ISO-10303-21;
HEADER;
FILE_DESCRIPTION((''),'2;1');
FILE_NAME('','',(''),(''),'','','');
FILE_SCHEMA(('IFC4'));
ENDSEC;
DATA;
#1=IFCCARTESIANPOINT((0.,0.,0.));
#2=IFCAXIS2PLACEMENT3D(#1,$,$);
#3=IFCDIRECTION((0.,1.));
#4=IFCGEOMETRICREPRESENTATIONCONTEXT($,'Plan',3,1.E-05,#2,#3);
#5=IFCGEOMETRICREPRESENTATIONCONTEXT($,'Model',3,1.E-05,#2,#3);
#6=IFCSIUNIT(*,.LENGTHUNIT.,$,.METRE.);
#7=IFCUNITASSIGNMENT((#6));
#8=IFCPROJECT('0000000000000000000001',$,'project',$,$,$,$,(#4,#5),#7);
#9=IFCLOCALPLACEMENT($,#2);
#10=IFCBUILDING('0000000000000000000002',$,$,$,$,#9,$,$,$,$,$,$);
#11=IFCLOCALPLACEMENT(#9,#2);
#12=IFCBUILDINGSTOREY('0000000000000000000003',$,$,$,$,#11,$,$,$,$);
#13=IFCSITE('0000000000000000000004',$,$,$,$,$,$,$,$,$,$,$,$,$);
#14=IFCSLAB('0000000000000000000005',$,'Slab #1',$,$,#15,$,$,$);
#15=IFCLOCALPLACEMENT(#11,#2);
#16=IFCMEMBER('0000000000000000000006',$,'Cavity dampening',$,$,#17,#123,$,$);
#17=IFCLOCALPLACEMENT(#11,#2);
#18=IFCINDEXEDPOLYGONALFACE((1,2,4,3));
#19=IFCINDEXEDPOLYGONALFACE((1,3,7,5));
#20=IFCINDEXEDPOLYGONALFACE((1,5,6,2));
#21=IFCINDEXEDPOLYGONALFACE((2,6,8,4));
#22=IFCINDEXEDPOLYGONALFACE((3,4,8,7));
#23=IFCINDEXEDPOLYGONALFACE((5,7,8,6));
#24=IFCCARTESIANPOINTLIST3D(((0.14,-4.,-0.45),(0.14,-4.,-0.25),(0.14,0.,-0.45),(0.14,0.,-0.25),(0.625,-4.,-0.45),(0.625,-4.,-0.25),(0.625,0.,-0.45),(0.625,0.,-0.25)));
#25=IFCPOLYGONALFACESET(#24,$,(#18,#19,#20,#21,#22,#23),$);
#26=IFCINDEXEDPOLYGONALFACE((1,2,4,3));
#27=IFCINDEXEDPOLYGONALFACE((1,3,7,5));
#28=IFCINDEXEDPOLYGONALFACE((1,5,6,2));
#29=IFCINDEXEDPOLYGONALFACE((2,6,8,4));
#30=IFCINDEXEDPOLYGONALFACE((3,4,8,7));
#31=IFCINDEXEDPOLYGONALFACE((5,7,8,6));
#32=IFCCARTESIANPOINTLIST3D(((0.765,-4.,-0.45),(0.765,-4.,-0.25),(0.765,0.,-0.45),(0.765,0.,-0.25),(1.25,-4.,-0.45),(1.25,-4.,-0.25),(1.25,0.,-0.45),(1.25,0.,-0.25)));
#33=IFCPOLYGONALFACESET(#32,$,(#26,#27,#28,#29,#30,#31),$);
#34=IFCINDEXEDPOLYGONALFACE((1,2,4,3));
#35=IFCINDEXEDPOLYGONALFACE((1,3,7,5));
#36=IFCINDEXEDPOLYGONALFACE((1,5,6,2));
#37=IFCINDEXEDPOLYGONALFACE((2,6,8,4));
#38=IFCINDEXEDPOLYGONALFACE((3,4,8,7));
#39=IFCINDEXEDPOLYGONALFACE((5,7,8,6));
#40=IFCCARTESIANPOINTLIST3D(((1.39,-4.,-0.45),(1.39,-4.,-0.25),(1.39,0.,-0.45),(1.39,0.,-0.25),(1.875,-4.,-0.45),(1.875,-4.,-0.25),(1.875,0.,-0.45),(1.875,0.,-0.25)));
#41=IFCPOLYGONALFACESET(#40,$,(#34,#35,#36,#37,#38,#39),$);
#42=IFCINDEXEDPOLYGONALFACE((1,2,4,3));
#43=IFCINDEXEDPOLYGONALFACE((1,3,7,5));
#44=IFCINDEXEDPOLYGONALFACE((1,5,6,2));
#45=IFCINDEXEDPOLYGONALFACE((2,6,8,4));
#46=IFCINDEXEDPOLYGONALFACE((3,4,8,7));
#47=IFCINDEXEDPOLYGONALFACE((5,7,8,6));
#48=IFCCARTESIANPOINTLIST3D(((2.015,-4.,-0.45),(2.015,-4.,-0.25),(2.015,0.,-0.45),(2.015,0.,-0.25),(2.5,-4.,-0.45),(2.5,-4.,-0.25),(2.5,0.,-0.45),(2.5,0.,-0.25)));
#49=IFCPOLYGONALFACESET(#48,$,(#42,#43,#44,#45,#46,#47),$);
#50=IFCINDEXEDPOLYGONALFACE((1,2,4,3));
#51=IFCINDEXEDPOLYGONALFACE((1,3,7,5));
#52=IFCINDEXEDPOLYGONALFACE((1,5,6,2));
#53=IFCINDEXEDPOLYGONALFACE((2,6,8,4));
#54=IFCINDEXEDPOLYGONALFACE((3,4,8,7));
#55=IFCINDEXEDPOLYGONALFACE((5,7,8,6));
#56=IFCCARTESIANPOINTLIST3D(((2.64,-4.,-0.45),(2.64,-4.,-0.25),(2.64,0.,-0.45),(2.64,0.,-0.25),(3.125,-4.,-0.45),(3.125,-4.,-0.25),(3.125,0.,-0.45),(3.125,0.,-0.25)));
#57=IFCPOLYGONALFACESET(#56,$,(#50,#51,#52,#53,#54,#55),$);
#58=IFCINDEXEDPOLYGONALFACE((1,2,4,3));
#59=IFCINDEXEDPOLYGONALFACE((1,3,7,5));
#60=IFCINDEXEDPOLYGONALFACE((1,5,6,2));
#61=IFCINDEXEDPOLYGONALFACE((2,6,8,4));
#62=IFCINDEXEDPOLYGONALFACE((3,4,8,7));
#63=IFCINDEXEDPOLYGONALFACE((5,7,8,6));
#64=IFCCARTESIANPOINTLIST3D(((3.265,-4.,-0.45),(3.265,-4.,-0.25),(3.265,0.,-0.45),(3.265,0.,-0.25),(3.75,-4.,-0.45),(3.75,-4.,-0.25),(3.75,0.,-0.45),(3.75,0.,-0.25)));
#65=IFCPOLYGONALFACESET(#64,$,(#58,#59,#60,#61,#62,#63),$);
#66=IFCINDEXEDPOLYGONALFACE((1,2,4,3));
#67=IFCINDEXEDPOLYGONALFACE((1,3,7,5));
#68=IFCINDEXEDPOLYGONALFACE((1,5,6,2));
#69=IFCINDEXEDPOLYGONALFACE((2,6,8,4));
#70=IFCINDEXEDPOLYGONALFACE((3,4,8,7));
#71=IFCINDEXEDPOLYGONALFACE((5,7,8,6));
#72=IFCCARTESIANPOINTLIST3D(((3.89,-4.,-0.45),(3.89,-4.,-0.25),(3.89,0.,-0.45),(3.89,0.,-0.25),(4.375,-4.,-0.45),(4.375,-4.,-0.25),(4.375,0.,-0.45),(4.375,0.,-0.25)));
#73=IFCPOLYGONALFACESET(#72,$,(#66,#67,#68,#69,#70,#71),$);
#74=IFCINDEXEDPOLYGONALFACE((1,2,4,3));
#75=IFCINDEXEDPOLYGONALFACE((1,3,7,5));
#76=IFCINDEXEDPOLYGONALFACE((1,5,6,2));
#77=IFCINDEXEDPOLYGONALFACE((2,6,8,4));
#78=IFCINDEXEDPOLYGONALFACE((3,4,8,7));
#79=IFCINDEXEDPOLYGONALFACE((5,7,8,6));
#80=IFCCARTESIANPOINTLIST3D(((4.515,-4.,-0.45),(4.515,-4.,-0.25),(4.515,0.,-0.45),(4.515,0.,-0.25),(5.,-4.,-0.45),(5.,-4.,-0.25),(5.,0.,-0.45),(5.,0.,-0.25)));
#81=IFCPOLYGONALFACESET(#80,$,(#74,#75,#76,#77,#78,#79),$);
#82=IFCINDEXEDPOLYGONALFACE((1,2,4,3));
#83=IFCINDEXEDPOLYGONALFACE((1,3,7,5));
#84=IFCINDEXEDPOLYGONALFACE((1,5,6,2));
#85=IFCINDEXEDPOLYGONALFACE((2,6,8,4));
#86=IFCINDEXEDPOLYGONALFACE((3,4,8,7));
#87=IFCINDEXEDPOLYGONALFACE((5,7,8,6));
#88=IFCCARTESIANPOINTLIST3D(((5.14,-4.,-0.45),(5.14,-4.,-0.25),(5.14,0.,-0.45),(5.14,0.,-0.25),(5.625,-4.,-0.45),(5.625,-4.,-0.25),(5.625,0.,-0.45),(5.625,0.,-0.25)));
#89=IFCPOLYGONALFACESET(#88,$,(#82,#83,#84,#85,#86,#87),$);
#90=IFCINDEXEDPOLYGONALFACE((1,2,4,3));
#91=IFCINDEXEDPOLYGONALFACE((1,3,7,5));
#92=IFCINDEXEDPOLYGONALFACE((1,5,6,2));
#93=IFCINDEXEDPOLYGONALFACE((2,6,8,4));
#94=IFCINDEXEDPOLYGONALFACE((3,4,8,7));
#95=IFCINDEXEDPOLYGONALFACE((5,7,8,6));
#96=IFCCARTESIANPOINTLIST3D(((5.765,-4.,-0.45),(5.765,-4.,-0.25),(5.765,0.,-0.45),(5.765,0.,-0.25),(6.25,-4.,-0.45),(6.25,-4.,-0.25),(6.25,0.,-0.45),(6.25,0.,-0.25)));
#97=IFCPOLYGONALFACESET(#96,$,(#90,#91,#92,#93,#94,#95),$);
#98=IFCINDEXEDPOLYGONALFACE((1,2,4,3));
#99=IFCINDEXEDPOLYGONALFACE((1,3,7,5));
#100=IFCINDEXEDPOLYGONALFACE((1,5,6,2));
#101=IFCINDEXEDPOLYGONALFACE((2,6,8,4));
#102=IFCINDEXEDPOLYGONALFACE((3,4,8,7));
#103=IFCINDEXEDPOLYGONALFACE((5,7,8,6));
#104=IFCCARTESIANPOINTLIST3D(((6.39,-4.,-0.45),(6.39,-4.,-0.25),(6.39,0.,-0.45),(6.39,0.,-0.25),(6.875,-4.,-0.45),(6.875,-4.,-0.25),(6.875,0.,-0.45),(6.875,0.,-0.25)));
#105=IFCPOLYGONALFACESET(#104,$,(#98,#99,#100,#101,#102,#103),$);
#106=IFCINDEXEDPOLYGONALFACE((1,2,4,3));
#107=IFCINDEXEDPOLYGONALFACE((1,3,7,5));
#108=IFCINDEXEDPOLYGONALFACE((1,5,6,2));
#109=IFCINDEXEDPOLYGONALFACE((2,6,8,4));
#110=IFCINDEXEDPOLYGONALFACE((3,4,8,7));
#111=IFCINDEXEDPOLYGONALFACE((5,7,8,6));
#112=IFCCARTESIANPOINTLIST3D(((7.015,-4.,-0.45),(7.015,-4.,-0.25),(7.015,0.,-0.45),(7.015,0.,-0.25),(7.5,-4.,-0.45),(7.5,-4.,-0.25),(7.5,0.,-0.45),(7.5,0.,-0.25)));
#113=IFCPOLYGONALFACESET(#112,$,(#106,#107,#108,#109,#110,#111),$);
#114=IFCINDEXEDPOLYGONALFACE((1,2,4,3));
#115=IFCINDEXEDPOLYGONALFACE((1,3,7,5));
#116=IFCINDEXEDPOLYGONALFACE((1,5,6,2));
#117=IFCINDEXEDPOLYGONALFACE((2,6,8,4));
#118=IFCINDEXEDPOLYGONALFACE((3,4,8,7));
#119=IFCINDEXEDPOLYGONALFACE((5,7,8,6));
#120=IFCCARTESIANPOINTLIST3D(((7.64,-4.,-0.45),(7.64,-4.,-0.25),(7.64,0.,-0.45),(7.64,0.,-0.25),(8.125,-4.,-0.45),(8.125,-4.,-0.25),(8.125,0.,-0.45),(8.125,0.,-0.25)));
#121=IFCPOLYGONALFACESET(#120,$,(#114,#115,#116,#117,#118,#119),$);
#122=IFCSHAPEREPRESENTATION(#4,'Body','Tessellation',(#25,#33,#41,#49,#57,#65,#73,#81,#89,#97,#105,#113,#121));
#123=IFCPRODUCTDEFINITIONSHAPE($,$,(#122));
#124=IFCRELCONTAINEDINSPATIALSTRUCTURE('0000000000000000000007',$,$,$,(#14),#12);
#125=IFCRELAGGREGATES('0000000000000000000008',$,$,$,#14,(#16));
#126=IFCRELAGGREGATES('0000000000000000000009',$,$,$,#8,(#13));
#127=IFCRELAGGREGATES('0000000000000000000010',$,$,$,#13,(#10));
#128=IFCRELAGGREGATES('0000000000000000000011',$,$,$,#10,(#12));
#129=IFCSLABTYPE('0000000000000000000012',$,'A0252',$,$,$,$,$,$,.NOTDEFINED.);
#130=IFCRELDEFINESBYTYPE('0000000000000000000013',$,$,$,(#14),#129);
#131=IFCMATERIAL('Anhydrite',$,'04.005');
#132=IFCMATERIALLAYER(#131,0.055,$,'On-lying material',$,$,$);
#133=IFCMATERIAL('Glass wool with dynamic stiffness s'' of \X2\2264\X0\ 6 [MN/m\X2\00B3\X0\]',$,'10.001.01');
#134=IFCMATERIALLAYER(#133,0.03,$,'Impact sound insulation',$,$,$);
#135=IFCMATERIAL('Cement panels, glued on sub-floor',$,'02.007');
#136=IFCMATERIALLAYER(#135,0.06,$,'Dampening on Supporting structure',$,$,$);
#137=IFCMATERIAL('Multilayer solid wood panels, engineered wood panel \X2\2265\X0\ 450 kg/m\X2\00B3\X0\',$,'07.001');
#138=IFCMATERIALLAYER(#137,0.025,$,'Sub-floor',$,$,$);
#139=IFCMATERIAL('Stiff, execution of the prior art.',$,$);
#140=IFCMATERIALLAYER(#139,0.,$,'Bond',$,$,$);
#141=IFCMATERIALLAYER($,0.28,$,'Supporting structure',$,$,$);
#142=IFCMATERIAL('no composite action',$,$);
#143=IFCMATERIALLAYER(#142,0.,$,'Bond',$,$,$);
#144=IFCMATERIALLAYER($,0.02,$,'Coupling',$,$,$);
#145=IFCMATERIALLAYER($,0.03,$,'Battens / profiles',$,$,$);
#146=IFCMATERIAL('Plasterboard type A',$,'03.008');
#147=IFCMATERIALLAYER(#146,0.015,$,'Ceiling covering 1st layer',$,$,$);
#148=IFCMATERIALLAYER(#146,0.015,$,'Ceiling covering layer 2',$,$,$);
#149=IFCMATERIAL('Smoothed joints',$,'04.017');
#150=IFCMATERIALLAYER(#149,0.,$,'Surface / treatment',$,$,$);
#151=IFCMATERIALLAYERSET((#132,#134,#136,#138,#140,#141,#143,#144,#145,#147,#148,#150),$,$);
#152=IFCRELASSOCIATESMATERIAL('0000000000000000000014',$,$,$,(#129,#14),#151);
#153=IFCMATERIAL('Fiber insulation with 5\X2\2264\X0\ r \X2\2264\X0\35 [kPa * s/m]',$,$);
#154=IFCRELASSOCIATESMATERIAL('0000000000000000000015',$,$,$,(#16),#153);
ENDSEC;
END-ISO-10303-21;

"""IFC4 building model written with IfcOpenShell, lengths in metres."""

from ifc_helpers import new_model, si_unit, direction, frame, frame_2d, origin, place, context, project, spatial, rectangle, extrude, material, layer, layer_set, type_object, element, aggregate, save


model = new_model("IFC4")

# Units and contexts
plan_context = context("Plan", 3, precision=1e-05, world=origin(), true_north=direction((0.0, 1.0)))
model_context = context("Model", 3, precision=1e-05, world=origin(), true_north=direction((0.0, 1.0)))
ifc_project = project(units=[si_unit("LENGTHUNIT", "METRE")], contexts=[plan_context, model_context])

# Site, building, storey
site = spatial("IfcSite", under=ifc_project)
building_placement = place(None, origin())
building = spatial("IfcBuilding", under=site, at=building_placement)
storey_placement = place(building_placement, origin())
storey = spatial("IfcBuildingStorey", under=building, at=storey_placement)

# Slab, member
ifc_material_1 = material(Name="Anhydrite", Category="04.005")
ifc_layer_1 = layer(ifc_material_1, 0.055, Name="On-lying material")
ifc_material_2 = material(Name="Glass wool with dynamic stiffness s' of ≤ 6 [MN/m³]", Category="10.001.01")
ifc_layer_2 = layer(ifc_material_2, 0.03, Name="Impact sound insulation")
ifc_material_3 = material(Name="Cement panels, glued on sub-floor", Category="02.007")
ifc_layer_3 = layer(ifc_material_3, 0.06, Name="Dampening on Supporting structure")
ifc_material_4 = material(Name="Multilayer solid wood panels, engineered wood panel ≥ 450 kg/m³", Category="07.001")
ifc_layer_4 = layer(ifc_material_4, 0.025, Name="Sub-floor")
ifc_material_5 = material(Name="Stiff, execution of the prior art.")
ifc_layer_5 = layer(ifc_material_5, 0.0, Name="Bond")
ifc_layer_6 = layer(None, 0.28, Name="Supporting structure")
ifc_material_6 = material(Name="no composite action")
ifc_layer_7 = layer(ifc_material_6, 0.0, Name="Bond")
ifc_layer_8 = layer(None, 0.02, Name="Coupling")
ifc_layer_9 = layer(None, 0.03, Name="Battens / profiles")
ifc_material_7 = material(Name="Plasterboard type A", Category="03.008")
ifc_layer_10 = layer(ifc_material_7, 0.015, Name="Ceiling covering 1st layer")
ifc_layer_11 = layer(ifc_material_7, 0.015, Name="Ceiling covering layer 2")
ifc_material_8 = material(Name="Smoothed joints", Category="04.017")
ifc_layer_12 = layer(ifc_material_8, 0.0, Name="Surface / treatment")
ifc_layer_set = layer_set([ifc_layer_1, ifc_layer_2, ifc_layer_3, ifc_layer_4, ifc_layer_5, ifc_layer_6, ifc_layer_7, ifc_layer_8, ifc_layer_9, ifc_layer_10, ifc_layer_11, ifc_layer_12])
slab_type = type_object("IfcSlabType", Name="A0252", PredefinedType="NOTDEFINED", material=ifc_layer_set)
slab_placement = place(None, frame((0.0, 0.0, 0.0), z_axis=(0.0, 0.0, -1.0), x_axis=(1.0, 0.0, 0.0)))
slab = element("IfcSlab", 1, at=slab_placement, inside=storey, type_object=slab_type, material=ifc_layer_set, Name="Slab #1")
ifc_material_9 = material(Name="Fiber insulation with 5≤ r ≤35 [kPa * s/m]")
member_1_placement = place(slab_placement, origin())
member_1 = element("IfcMember", 2, at=member_1_placement, material=ifc_material_9, Name="Cavity dampening", context=plan_context, shape_type="SweptSolid", body=[
    extrude(rectangle(XDim=0.485, YDim=0.2, at=frame_2d((0.2425, 0.1), x_axis=(1.0, 0.0))), frame((0.14, 4.0, 0.25), z_axis=(0.0, -1.0, 0.0), x_axis=(1.0, 0.0, 0.0)), (0.0, 0.0, 1.0), 4.0),
    extrude(rectangle(XDim=0.485, YDim=0.2, at=frame_2d((0.2425, 0.1), x_axis=(1.0, 0.0))), frame((0.765, 4.0, 0.25), z_axis=(0.0, -1.0, 0.0), x_axis=(1.0, 0.0, 0.0)), (0.0, 0.0, 1.0), 4.0),
    extrude(rectangle(XDim=0.485, YDim=0.2, at=frame_2d((0.2425, 0.1), x_axis=(1.0, 0.0))), frame((1.39, 4.0, 0.25), z_axis=(0.0, -1.0, 0.0), x_axis=(1.0, 0.0, 0.0)), (0.0, 0.0, 1.0), 4.0),
    extrude(rectangle(XDim=0.485, YDim=0.2, at=frame_2d((0.2425, 0.1), x_axis=(1.0, 0.0))), frame((2.015, 4.0, 0.25), z_axis=(0.0, -1.0, 0.0), x_axis=(1.0, 0.0, 0.0)), (0.0, 0.0, 1.0), 4.0),
    extrude(rectangle(XDim=0.485, YDim=0.2, at=frame_2d((0.2425, 0.1), x_axis=(1.0, 0.0))), frame((2.64, 4.0, 0.25), z_axis=(0.0, -1.0, 0.0), x_axis=(1.0, 0.0, 0.0)), (0.0, 0.0, 1.0), 4.0),
    extrude(rectangle(XDim=0.485, YDim=0.2, at=frame_2d((0.2425, 0.1), x_axis=(1.0, 0.0))), frame((3.265, 4.0, 0.25), z_axis=(0.0, -1.0, 0.0), x_axis=(1.0, 0.0, 0.0)), (0.0, 0.0, 1.0), 4.0),
    extrude(rectangle(XDim=0.485, YDim=0.2, at=frame_2d((0.2425, 0.1), x_axis=(1.0, 0.0))), frame((3.89, 4.0, 0.25), z_axis=(0.0, -1.0, 0.0), x_axis=(1.0, 0.0, 0.0)), (0.0, 0.0, 1.0), 4.0),
    extrude(rectangle(XDim=0.485, YDim=0.2, at=frame_2d((0.2425, 0.1), x_axis=(1.0, 0.0))), frame((4.515, 4.0, 0.25), z_axis=(0.0, -1.0, 0.0), x_axis=(1.0, 0.0, 0.0)), (0.0, 0.0, 1.0), 4.0),
    extrude(rectangle(XDim=0.485, YDim=0.2, at=frame_2d((0.2425, 0.1), x_axis=(1.0, 0.0))), frame((5.14, 4.0, 0.25), z_axis=(0.0, -1.0, 0.0), x_axis=(1.0, 0.0, 0.0)), (0.0, 0.0, 1.0), 4.0),
    extrude(rectangle(XDim=0.485, YDim=0.2, at=frame_2d((0.2425, 0.1), x_axis=(1.0, 0.0))), frame((5.765, 4.0, 0.25), z_axis=(0.0, -1.0, 0.0), x_axis=(1.0, 0.0, 0.0)), (0.0, 0.0, 1.0), 4.0),
    extrude(rectangle(XDim=0.485, YDim=0.2, at=frame_2d((0.2425, 0.1), x_axis=(1.0, 0.0))), frame((6.39, 4.0, 0.25), z_axis=(0.0, -1.0, 0.0), x_axis=(1.0, 0.0, 0.0)), (0.0, 0.0, 1.0), 4.0),
    extrude(rectangle(XDim=0.485, YDim=0.2, at=frame_2d((0.2425, 0.1), x_axis=(1.0, 0.0))), frame((7.015, 4.0, 0.25), z_axis=(0.0, -1.0, 0.0), x_axis=(1.0, 0.0, 0.0)), (0.0, 0.0, 1.0), 4.0),
    extrude(rectangle(XDim=0.485, YDim=0.2, at=frame_2d((0.2425, 0.1), x_axis=(1.0, 0.0))), frame((7.64, 4.0, 0.25), z_axis=(0.0, -1.0, 0.0), x_axis=(1.0, 0.0, 0.0)), (0.0, 0.0, 1.0), 4.0),
])
aggregate(slab, [member_1])

save(model, "model.ifc")
